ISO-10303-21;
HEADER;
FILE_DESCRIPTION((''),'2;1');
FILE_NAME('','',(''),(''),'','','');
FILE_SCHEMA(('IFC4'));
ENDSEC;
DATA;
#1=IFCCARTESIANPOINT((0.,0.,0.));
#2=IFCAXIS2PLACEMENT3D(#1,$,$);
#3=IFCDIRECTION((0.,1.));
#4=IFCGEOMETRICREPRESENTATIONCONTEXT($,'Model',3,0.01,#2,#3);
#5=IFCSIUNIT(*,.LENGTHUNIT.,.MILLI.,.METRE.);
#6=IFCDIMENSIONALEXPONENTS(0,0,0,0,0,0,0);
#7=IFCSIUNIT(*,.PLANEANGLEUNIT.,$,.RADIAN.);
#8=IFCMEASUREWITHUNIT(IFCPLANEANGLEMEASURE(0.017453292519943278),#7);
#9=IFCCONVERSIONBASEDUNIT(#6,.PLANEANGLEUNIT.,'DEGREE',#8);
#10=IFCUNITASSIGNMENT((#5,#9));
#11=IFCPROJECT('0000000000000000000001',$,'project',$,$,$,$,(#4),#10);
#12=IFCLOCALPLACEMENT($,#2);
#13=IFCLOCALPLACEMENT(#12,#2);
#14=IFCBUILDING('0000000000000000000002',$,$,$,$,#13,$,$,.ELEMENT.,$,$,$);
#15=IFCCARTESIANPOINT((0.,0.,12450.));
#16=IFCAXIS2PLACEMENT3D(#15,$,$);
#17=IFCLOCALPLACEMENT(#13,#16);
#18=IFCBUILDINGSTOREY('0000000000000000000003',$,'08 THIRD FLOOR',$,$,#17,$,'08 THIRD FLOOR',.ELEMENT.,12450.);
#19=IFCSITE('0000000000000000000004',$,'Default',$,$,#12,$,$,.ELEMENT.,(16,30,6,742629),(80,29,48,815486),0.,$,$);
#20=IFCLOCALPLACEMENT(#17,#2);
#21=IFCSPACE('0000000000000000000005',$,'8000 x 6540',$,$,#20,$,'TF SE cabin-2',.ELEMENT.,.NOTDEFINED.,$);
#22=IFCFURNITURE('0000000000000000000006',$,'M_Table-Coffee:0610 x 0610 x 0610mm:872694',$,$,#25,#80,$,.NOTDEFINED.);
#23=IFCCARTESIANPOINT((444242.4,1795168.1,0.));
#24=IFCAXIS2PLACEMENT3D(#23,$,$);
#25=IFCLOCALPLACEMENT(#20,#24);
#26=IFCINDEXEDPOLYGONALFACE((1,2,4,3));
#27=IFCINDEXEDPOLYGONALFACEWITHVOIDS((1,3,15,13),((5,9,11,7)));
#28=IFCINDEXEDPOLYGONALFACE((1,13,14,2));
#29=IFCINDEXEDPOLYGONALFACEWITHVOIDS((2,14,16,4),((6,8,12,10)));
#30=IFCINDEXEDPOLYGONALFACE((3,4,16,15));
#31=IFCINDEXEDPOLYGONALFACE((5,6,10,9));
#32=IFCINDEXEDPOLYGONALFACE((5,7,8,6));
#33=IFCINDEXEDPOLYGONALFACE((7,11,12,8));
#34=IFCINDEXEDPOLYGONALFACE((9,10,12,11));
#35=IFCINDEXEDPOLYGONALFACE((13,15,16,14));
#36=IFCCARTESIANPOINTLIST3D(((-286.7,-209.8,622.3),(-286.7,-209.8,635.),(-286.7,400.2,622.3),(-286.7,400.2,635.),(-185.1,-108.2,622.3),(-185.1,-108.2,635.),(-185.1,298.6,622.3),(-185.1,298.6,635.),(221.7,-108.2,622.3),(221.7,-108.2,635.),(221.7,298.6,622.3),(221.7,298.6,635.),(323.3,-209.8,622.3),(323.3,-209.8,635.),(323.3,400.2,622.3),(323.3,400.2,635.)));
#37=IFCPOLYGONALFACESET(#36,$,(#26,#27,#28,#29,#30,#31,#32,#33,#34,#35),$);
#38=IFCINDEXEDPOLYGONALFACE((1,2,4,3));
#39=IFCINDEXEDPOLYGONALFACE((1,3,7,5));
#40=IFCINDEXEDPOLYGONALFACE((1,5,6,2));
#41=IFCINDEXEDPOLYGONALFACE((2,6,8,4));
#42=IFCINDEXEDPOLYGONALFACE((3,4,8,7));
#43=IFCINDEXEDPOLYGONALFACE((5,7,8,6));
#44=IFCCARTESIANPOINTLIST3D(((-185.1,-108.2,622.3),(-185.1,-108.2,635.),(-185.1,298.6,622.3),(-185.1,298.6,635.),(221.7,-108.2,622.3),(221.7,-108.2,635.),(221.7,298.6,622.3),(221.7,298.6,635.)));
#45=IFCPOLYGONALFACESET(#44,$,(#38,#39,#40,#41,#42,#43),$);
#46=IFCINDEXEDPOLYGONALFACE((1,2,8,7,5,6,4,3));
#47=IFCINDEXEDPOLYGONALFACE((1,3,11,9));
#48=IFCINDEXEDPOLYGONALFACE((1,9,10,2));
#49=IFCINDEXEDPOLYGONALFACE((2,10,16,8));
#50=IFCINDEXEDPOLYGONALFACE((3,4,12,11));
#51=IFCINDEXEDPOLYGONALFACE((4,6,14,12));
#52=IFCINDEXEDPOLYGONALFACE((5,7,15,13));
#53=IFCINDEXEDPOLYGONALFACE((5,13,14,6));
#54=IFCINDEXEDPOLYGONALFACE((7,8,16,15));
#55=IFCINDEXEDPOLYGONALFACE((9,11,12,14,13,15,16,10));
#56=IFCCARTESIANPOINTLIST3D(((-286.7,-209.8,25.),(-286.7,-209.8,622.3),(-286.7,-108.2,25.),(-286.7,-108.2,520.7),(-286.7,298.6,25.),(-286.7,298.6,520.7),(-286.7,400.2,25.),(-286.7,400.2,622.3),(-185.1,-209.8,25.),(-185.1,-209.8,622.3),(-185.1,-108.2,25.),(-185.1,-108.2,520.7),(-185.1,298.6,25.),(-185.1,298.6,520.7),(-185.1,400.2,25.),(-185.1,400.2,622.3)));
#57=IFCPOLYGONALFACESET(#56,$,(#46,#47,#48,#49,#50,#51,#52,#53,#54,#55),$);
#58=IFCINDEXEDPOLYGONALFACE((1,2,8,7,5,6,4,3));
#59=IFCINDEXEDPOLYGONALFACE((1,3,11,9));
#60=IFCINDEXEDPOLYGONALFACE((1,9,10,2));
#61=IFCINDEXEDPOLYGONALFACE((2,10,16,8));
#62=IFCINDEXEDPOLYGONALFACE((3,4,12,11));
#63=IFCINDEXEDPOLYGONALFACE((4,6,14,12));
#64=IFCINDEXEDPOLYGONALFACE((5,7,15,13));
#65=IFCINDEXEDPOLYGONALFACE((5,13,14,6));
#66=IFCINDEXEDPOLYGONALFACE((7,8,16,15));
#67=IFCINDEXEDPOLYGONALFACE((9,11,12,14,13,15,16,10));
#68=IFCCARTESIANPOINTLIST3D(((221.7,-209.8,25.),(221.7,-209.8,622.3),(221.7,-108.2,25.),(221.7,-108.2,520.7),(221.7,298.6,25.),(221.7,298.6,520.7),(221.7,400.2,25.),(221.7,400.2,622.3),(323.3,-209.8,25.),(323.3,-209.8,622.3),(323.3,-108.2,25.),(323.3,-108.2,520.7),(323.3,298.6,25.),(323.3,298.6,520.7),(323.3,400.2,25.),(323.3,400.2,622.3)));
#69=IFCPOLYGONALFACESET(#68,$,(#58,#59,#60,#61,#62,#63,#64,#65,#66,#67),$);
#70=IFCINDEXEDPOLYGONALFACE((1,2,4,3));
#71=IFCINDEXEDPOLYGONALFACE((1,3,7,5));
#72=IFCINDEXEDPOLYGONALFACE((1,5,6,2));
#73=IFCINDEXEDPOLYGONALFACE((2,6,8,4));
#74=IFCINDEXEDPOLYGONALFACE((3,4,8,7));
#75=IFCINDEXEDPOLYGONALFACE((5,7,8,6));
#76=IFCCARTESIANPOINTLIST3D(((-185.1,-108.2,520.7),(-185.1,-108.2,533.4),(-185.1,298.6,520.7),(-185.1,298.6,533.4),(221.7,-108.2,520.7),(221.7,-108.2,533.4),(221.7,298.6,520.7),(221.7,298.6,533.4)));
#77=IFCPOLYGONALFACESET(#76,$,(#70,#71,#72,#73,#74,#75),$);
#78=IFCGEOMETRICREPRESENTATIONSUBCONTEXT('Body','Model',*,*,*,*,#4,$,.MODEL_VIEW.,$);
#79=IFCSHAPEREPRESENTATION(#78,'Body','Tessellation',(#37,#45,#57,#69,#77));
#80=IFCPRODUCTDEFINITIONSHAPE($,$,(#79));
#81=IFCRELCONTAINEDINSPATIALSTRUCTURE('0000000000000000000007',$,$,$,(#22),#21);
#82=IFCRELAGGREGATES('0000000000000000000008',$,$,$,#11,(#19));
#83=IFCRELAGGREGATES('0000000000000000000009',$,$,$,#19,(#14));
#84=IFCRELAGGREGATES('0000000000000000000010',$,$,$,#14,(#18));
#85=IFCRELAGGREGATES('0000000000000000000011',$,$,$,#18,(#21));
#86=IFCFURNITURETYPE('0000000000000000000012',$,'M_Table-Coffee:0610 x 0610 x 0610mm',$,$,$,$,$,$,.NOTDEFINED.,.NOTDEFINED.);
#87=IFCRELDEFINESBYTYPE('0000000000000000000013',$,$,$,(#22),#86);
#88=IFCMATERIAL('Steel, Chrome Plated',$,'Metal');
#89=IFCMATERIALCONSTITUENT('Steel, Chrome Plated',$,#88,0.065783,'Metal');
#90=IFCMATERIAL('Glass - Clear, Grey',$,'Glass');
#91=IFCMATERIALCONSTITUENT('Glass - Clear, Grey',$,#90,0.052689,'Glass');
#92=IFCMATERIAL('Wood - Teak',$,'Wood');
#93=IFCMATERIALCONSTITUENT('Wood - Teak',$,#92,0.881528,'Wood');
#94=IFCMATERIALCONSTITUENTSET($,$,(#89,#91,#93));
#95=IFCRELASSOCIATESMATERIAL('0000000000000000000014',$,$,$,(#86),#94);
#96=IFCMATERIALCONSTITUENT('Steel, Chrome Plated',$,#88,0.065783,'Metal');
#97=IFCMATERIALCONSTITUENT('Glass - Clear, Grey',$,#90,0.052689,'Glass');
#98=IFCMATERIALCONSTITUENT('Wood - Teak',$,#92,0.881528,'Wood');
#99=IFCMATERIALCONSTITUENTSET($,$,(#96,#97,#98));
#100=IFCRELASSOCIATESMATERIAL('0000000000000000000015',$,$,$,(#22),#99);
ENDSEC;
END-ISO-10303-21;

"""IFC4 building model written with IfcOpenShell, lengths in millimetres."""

from ifc_helpers import new_model, entity, si_unit, converted_unit, direction, frame, origin, place, context, subcontext, project, spatial, indexed_curve, outline, extrude, source, transform, mapped, material, constituent, constituent_set, type_object, type_shapes, element, save


model = new_model("IFC4")

# Units and contexts
model_context = context("Model", 3, precision=0.01, world=origin(), true_north=direction((0.0, 1.0)))
body_context = subcontext(model_context, "Body", "Model", "MODEL_VIEW")
ifc_project = project(units=[si_unit("LENGTHUNIT", "METRE", prefix="MILLI"), converted_unit("PLANEANGLEUNIT", "DEGREE", entity("IfcPlaneAngleMeasure", 0.017453292519943278), si_unit("PLANEANGLEUNIT", "RADIAN"), dimensions=[0, 0, 0, 0, 0, 0, 0])], contexts=[model_context])

# Site, building, storey
site_placement = place(None, origin())
site = spatial("IfcSite", under=ifc_project, at=site_placement, Name="Default", CompositionType="ELEMENT", RefLatitude=(16, 30, 6, 742629), RefLongitude=(80, 29, 48, 815486), RefElevation=0.0)
building_placement = place(site_placement, origin())
building = spatial("IfcBuilding", under=site, at=building_placement, CompositionType="ELEMENT")
storey_placement = place(building_placement, frame((0.0, 0.0, 12450.0)))
storey = spatial("IfcBuildingStorey", under=building, at=storey_placement, Name="08 THIRD FLOOR", LongName="08 THIRD FLOOR", CompositionType="ELEMENT", Elevation=12450.0)

# Shared definitions
space_1_placement = place(storey_placement, origin())
space_1 = spatial("IfcSpace", under=storey, at=space_1_placement, Name="8000 x 6540", LongName="TF SE cabin-2", CompositionType="ELEMENT", PredefinedType="NOTDEFINED")

# Furniture
ifc_material_1 = material(Name="Steel, Chrome Plated", Category="Metal")
ifc_constituent_1 = constituent(ifc_material_1, Name="Steel, Chrome Plated", Category="Metal", fraction=0.065783)
ifc_material_2 = material(Name="Glass - Clear, Grey", Category="Glass")
ifc_constituent_2 = constituent(ifc_material_2, Name="Glass - Clear, Grey", Category="Glass", fraction=0.052689)
ifc_material_3 = material(Name="Wood - Teak", Category="Wood")
ifc_constituent_3 = constituent(ifc_material_3, Name="Wood - Teak", Category="Wood", fraction=0.881528)
ifc_constituent_set_1 = constituent_set(constituents=[ifc_constituent_1, ifc_constituent_2, ifc_constituent_3])
ifc_constituent_4 = constituent(ifc_material_1, Name="Steel, Chrome Plated", Category="Metal", fraction=0.065783)
ifc_constituent_5 = constituent(ifc_material_2, Name="Glass - Clear, Grey", Category="Glass", fraction=0.052689)
ifc_constituent_6 = constituent(ifc_material_3, Name="Wood - Teak", Category="Wood", fraction=0.881528)
ifc_constituent_set_2 = constituent_set(constituents=[ifc_constituent_4, ifc_constituent_5, ifc_constituent_6])
furniture_type_1 = type_object("IfcFurnitureType", Name="M_Table-Coffee:0610 x 0610 x 0610mm", AssemblyPlace="NOTDEFINED", PredefinedType="NOTDEFINED", material=ifc_constituent_set_2)
shared_shape_1 = source(origin(), body_context, "Body", "SweptSolid", [
    extrude(outline(indexed_curve([(-305.0, -305.0), (305.0, -305.0), (305.0, 305.0), (-305.0, 305.0), (-305.0, -305.0)], self_intersect=False), holes=[indexed_curve([(-203.4, -203.4), (-203.4, 203.4), (203.4, 203.4), (203.4, -203.4), (-203.4, -203.4)], self_intersect=False)]), frame((18.3, 95.2, 622.3), z_axis=(0.0, 0.0, 1.0), x_axis=(-1.0, 0.0, 0.0)), (0.0, 0.0, 1.0), 12.7),
    extrude(outline(indexed_curve([(-203.4, -203.4), (203.4, -203.4), (203.4, 203.4), (-203.4, 203.4), (-203.4, -203.4)], self_intersect=False)), frame((18.3, 95.2, 622.3), z_axis=(0.0, 0.0, 1.0), x_axis=(-1.0, 0.0, 0.0)), (0.0, 0.0, 1.0), 12.7),
    extrude(outline(indexed_curve([(-305.0, -324.1), (305.0, -324.1), (305.0, 273.3), (203.4, 273.3), (203.4, -222.4), (-203.4, -222.4), (-203.4, 273.3), (-305.0, 273.3), (-305.0, -324.1)], self_intersect=False)), frame((-286.7, 95.2, 298.3), z_axis=(1.0, 0.0, 0.0), x_axis=(0.0, -1.0, 0.0)), (0.0, 0.0, 1.0), 101.6),
    extrude(outline(indexed_curve([(-273.2, -305.0), (324.0, -305.0), (324.0, 305.0), (-273.2, 305.0), (-273.2, 203.4), (222.5, 203.4), (222.5, -203.4), (-273.2, -203.4), (-273.2, -305.0)], self_intersect=False)), frame((221.7, 95.2, 298.2), z_axis=(1.0, 0.0, 0.0), x_axis=(0.0, 0.0, 1.0)), (0.0, 0.0, 1.0), 101.6),
    extrude(outline(indexed_curve([(-203.4, -203.4), (203.4, -203.4), (203.4, 203.4), (-203.4, 203.4), (-203.4, -203.4)], self_intersect=False)), frame((18.3, 95.2, 520.7), z_axis=(0.0, 0.0, 1.0), x_axis=(-1.0, 0.0, 0.0)), (0.0, 0.0, 1.0), 12.7),
])
type_shapes(furniture_type_1, [shared_shape_1])
furniture_1_placement = place(space_1_placement, frame((444242.4, 1795168.1, 0.0)))
element("IfcFurniture", 1, at=furniture_1_placement, inside=space_1, type_object=furniture_type_1, material=ifc_constituent_set_1, Name="M_Table-Coffee:0610 x 0610 x 0610mm:872694", PredefinedType="NOTDEFINED", context=body_context, shape_type="MappedRepresentation", body=[
    mapped(shared_shape_1, transform((0.0, 0.0, 0.0), scale=1.0)),
])

save(model, "model.ifc")
